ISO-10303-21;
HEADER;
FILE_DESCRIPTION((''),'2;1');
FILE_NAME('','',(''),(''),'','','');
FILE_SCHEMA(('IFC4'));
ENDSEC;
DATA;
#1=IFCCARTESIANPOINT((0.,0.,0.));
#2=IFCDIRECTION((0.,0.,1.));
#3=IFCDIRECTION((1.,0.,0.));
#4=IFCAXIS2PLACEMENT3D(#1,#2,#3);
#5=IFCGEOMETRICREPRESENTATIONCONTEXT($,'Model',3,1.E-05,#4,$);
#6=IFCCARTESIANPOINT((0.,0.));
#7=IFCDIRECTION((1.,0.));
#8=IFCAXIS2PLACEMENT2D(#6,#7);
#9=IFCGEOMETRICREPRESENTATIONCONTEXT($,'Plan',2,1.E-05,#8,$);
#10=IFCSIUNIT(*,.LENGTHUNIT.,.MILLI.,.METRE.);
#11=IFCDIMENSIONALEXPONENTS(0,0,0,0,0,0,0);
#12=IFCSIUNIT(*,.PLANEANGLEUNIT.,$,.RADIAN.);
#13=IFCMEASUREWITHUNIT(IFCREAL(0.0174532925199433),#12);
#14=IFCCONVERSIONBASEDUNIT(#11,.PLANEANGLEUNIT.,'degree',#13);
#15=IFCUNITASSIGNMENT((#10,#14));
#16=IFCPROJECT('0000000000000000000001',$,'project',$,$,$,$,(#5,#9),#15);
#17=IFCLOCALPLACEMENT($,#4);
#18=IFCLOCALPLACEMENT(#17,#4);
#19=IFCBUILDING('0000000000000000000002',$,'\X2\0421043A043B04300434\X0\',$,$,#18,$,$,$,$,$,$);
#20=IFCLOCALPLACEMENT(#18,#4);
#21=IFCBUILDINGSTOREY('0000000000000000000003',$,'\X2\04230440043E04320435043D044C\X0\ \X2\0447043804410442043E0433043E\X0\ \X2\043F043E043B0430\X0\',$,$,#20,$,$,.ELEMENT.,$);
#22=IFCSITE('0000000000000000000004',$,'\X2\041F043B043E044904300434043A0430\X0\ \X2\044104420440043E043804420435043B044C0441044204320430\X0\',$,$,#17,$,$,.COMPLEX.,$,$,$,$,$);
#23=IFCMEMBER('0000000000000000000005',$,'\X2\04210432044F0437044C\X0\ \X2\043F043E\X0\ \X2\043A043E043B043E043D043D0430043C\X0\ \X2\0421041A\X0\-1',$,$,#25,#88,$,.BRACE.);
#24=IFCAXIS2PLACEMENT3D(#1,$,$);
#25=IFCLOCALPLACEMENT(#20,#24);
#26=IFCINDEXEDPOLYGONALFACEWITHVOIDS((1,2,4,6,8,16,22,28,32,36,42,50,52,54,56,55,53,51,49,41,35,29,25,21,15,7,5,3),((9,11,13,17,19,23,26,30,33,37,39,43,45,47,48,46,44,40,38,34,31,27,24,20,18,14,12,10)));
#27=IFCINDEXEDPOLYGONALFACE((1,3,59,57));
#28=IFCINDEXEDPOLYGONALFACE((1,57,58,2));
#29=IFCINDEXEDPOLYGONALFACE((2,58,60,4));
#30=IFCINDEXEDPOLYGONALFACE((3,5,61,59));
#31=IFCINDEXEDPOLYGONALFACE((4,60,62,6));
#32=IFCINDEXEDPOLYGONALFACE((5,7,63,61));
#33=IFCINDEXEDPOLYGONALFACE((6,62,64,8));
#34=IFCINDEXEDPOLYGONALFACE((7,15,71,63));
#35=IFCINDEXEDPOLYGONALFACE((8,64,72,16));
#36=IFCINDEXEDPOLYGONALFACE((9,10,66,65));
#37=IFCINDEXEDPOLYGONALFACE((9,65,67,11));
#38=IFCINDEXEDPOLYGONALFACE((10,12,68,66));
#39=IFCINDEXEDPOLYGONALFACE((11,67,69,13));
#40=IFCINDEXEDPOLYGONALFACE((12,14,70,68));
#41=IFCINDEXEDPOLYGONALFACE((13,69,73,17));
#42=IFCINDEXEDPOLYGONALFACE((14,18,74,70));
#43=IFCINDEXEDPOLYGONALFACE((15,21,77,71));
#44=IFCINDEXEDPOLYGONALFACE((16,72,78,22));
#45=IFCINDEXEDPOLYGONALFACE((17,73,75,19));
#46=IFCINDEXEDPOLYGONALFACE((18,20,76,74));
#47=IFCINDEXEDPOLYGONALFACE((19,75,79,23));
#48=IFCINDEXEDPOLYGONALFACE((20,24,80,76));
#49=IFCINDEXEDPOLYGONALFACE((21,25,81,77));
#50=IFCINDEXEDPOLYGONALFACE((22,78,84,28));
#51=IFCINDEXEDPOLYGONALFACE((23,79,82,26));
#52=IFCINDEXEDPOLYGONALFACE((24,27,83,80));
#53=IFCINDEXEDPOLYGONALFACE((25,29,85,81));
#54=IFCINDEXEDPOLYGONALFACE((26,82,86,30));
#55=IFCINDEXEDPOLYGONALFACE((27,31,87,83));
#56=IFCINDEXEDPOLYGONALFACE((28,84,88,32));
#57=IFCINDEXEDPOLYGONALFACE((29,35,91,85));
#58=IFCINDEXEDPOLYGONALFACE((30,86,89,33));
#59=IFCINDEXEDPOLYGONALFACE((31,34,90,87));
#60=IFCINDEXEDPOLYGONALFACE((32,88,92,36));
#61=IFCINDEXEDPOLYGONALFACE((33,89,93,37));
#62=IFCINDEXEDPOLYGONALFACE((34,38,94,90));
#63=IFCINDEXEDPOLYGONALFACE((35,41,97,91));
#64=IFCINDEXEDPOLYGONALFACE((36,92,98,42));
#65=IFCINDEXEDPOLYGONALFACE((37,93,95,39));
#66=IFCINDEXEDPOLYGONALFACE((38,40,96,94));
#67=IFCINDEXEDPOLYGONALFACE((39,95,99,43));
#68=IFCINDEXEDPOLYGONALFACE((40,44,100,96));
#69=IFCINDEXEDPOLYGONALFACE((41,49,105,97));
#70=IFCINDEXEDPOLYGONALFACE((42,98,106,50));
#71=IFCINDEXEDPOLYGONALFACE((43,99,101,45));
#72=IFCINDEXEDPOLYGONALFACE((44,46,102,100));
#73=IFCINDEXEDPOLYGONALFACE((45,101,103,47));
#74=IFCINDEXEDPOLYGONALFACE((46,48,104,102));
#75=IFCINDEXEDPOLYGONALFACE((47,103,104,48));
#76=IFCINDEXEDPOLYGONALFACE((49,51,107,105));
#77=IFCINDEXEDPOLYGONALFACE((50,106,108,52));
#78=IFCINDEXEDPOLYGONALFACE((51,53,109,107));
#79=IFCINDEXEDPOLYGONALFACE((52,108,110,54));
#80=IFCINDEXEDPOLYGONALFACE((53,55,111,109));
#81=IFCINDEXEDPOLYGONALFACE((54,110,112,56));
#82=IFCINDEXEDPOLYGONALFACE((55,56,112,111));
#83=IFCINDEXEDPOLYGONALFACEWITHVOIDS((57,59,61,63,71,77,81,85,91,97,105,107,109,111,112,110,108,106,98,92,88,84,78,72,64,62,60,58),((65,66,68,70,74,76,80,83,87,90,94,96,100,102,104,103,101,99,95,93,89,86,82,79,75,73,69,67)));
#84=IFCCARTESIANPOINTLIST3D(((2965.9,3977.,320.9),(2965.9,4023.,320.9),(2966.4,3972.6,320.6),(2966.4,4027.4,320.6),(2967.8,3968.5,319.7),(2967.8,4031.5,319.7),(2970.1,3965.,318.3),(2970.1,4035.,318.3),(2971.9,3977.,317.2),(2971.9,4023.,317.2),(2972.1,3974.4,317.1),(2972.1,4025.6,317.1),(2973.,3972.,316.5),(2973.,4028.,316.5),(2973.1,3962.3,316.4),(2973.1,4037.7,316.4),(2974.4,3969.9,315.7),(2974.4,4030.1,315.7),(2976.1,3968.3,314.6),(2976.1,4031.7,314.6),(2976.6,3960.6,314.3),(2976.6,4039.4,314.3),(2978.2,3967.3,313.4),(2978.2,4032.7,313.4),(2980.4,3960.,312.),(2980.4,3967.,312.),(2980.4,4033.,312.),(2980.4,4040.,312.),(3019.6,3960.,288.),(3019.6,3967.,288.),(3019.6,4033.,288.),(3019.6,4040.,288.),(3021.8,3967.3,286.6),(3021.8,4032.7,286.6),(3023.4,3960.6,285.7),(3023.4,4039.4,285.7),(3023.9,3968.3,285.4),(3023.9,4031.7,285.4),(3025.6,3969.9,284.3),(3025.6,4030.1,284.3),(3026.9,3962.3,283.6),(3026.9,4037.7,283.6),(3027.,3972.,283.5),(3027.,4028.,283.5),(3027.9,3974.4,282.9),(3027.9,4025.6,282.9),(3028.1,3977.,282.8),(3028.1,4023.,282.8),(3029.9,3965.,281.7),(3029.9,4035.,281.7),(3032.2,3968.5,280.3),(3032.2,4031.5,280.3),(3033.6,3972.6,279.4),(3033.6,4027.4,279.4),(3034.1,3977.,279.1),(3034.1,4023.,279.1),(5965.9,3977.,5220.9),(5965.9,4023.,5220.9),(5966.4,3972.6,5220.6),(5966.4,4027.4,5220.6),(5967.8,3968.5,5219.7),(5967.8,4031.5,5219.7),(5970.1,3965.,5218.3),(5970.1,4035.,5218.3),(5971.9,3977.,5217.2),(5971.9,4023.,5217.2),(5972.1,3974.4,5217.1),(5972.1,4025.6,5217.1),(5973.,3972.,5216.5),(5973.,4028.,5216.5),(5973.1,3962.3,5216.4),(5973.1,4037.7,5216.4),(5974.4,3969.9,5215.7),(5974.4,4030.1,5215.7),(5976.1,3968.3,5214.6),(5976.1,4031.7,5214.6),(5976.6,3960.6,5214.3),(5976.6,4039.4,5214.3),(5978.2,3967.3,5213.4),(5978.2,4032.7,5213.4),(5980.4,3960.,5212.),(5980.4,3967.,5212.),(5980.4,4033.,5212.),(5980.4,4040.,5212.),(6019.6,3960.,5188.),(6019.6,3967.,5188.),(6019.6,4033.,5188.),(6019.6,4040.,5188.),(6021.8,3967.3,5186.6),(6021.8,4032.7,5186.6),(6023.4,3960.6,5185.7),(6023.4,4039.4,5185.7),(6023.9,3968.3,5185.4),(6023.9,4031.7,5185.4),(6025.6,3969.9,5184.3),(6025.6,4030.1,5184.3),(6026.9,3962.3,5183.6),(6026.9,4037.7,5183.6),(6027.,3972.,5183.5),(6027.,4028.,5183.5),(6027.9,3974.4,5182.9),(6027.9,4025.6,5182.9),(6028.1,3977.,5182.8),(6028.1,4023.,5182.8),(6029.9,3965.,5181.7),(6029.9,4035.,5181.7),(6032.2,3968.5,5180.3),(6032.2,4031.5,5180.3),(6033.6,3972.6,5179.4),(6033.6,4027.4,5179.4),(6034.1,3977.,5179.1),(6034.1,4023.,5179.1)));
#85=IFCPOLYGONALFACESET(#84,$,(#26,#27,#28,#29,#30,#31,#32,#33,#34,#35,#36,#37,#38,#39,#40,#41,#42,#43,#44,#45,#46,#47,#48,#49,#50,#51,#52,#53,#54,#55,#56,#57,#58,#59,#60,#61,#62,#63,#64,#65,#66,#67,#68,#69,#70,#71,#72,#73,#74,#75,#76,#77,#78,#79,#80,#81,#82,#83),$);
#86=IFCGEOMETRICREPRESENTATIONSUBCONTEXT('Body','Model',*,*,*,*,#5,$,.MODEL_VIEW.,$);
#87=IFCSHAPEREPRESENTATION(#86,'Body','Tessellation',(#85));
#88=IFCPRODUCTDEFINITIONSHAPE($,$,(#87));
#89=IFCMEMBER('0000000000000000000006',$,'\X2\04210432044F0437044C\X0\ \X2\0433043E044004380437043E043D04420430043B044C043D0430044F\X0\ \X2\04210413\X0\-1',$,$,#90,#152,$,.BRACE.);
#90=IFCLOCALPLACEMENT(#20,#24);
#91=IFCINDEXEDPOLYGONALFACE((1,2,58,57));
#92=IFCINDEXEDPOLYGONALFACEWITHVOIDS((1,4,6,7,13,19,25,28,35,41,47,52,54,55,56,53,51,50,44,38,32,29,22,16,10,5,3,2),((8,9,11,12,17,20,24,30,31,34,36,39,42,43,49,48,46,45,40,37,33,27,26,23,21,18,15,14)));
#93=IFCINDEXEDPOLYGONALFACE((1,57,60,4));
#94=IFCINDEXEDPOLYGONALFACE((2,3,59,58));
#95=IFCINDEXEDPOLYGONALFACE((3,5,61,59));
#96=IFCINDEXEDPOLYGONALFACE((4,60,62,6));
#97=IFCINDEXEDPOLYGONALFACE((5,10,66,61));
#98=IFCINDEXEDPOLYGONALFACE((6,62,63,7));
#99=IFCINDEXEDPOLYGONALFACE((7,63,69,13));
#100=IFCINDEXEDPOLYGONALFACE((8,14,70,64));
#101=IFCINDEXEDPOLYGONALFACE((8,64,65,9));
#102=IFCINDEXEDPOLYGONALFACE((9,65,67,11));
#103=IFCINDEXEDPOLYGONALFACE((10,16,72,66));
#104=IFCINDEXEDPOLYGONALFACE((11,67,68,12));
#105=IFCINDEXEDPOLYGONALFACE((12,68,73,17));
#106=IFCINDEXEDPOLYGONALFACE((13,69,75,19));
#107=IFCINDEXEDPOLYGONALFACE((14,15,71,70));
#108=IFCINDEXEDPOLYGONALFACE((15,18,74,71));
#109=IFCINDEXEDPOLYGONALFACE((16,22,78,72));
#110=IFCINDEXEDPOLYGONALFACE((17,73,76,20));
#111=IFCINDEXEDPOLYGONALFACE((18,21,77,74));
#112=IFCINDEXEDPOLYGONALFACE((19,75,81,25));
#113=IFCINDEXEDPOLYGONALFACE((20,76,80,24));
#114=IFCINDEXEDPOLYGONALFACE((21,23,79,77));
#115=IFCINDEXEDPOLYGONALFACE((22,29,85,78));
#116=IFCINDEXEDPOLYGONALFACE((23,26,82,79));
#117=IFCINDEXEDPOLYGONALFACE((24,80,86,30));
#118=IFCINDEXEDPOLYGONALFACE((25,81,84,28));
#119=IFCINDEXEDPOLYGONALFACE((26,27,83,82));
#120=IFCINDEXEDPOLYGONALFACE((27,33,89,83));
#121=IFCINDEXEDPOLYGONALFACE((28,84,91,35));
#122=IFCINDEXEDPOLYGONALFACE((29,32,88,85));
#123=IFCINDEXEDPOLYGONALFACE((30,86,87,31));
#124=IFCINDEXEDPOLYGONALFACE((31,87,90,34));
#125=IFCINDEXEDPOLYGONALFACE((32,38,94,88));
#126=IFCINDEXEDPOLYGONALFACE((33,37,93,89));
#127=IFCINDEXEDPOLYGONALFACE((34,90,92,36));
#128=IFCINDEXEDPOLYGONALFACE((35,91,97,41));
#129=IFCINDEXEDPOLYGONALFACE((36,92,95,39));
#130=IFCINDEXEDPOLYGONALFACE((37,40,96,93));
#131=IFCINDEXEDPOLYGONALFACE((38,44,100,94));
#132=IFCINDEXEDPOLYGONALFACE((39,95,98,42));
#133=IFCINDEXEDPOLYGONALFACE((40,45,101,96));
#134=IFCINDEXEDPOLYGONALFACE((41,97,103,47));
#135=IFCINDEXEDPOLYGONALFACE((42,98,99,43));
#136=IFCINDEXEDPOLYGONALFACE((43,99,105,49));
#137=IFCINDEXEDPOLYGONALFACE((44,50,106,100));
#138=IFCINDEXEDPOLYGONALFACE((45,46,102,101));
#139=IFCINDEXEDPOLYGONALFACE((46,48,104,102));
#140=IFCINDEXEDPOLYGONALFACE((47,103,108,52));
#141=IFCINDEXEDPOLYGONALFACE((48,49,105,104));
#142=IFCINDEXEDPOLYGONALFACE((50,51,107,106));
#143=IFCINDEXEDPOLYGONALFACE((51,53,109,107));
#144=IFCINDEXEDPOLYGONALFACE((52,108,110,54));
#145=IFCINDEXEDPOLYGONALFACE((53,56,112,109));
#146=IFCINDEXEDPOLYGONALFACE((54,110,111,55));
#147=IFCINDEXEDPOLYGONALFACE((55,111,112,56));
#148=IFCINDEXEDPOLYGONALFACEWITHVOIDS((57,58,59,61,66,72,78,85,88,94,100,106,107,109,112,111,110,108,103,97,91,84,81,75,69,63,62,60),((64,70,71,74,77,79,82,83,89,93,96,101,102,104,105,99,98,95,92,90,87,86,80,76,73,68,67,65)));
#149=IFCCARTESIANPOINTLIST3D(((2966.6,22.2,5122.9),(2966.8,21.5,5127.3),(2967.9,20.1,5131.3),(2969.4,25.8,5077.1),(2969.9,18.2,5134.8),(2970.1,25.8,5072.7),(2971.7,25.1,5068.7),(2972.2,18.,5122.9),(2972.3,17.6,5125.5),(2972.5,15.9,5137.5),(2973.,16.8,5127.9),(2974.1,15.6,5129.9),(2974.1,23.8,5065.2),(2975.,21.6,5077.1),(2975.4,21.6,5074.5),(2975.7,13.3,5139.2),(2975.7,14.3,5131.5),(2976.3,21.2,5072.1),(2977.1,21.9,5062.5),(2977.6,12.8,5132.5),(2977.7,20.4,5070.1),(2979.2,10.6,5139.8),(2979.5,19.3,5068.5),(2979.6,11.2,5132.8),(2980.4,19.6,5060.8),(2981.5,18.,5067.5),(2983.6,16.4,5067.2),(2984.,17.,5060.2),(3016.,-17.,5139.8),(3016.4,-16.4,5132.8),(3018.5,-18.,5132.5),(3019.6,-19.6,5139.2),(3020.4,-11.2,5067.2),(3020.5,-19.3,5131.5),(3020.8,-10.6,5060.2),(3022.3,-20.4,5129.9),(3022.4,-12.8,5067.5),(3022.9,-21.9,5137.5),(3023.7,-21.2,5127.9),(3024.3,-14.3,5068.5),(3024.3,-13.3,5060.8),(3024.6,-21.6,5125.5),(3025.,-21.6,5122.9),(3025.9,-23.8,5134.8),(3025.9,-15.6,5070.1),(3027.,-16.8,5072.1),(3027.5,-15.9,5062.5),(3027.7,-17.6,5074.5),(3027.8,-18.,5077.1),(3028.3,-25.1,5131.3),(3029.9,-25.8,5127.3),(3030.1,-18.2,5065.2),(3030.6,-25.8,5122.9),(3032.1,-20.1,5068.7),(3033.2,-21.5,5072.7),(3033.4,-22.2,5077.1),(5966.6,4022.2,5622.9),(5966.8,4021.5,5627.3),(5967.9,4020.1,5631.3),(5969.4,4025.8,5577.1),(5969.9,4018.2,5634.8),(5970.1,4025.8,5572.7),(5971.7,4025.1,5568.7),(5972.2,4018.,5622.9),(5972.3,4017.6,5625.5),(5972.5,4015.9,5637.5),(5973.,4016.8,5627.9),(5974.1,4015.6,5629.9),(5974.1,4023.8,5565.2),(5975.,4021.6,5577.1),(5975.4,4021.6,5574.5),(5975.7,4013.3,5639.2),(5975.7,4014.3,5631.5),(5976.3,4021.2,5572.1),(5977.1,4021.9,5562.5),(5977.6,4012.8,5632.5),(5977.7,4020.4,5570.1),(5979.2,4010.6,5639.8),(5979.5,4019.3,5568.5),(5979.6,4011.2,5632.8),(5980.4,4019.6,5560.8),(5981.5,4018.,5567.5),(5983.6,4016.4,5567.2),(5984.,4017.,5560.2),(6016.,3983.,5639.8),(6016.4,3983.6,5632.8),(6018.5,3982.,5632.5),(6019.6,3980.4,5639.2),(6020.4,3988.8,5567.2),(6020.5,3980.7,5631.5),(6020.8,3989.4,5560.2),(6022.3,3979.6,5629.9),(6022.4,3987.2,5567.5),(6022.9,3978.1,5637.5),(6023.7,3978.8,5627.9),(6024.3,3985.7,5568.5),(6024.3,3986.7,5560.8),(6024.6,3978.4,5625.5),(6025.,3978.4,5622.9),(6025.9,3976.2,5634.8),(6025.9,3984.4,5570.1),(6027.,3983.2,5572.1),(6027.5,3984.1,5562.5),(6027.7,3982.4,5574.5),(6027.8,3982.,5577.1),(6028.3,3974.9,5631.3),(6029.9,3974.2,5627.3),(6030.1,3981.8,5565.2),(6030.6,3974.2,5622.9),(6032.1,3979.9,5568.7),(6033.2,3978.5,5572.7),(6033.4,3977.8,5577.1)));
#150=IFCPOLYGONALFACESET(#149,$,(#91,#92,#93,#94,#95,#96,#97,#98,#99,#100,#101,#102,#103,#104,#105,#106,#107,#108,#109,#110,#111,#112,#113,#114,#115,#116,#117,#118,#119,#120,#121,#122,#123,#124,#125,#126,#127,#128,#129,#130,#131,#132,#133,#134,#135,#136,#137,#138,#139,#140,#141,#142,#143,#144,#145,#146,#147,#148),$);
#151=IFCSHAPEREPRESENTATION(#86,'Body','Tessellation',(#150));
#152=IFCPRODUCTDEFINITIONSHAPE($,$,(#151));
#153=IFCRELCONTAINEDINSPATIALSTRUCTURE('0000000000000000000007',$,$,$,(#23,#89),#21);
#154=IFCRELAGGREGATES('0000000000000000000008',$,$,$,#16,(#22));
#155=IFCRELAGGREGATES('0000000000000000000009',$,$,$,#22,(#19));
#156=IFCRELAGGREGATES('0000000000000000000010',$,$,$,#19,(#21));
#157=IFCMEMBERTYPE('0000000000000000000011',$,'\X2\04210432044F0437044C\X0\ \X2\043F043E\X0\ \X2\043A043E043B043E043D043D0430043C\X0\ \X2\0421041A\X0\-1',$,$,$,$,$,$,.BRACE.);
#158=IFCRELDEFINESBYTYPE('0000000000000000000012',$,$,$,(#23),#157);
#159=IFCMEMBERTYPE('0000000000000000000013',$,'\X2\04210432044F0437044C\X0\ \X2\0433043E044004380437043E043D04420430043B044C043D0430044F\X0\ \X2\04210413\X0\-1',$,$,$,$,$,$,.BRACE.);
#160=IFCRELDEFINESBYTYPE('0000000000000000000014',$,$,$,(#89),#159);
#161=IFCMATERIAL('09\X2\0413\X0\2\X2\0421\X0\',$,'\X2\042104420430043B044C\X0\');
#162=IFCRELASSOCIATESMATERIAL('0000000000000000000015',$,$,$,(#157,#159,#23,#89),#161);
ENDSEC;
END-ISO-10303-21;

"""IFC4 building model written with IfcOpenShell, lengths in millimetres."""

from ifc_helpers import new_model, entity, si_unit, converted_unit, frame, origin_with_axes, origin_2d_with_axis, place, context, subcontext, project, spatial, hollow_rectangle, extrude, material, material_profile, profile_set, profile_usage, type_object, element, save


model = new_model("IFC4")

# Units and contexts
model_context = context("Model", 3, precision=1e-05, world=origin_with_axes())
plan_context = context("Plan", 2, precision=1e-05, world=origin_2d_with_axis())
body_context = subcontext(model_context, "Body", "Model", "MODEL_VIEW")
ifc_project = project(units=[si_unit("LENGTHUNIT", "METRE", prefix="MILLI"), converted_unit("PLANEANGLEUNIT", "degree", entity("IfcReal", 0.0174532925199433), si_unit("PLANEANGLEUNIT", "RADIAN"), dimensions=[0, 0, 0, 0, 0, 0, 0])], contexts=[model_context, plan_context])

# Site, building, storey
site_placement = place(None, origin_with_axes())
site = spatial("IfcSite", under=ifc_project, at=site_placement, Name="Площадка строительства", CompositionType="COMPLEX")
building_placement = place(site_placement, origin_with_axes())
building = spatial("IfcBuilding", under=site, at=building_placement, Name="Склад")
storey_placement = place(building_placement, origin_with_axes())
storey = spatial("IfcBuildingStorey", under=building, at=storey_placement, Name="Уровень чистого пола", CompositionType="ELEMENT")

# Members
ifc_material_1 = material(Name="09Г2С", Category="Сталь")
ifc_material_profile_1 = material_profile(ifc_material_1, hollow_rectangle(XDim=80.0, YDim=80.0, WallThickness=7.0, InnerFilletRadius=10.0, OuterFilletRadius=17.0))
ifc_profile_set_1 = profile_set([ifc_material_profile_1], Name="PK80x7_09G2S")
ifc_profile_usage_1 = profile_usage(ifc_profile_set_1, cardinal=5)
member_type_1 = type_object("IfcMemberType", Name="Связь по колоннам СК-1", PredefinedType="BRACE", material=ifc_profile_set_1)
member_1_placement = place(storey_placement, frame((3000.0, 4000.0, 300.0), z_axis=(0.522154, 0.0, 0.852851), x_axis=(0.0, 1.0, 0.0)))
element("IfcMember", 1, at=member_1_placement, inside=storey, type_object=member_type_1, material=ifc_profile_usage_1, Name="Связь по колоннам СК-1", PredefinedType="BRACE", context=body_context, shape_type="SweptSolid", body=[
    extrude(hollow_rectangle(XDim=80.0, YDim=80.0, WallThickness=7.0, InnerFilletRadius=10.0, OuterFilletRadius=17.0), origin_with_axes(), (0.0, 0.0, 1.0), 5745.4),
])
member_type_2 = type_object("IfcMemberType", Name="Связь горизонтальная СГ-1", PredefinedType="BRACE", material=ifc_profile_set_1)
member_2_placement = place(storey_placement, frame((3000.0, 0.0, 5100.0), z_axis=(0.597022, 0.79603, 0.099504), x_axis=(-0.8, 0.6, 0.0)))
element("IfcMember", 2, at=member_2_placement, inside=storey, type_object=member_type_2, material=ifc_profile_usage_1, Name="Связь горизонтальная СГ-1", PredefinedType="BRACE", context=body_context, shape_type="SweptSolid", body=[
    extrude(hollow_rectangle(XDim=80.0, YDim=80.0, WallThickness=7.0, InnerFilletRadius=10.0, OuterFilletRadius=17.0), origin_with_axes(), (0.0, 0.0, 1.0), 5024.9),
])

save(model, "model.ifc")
